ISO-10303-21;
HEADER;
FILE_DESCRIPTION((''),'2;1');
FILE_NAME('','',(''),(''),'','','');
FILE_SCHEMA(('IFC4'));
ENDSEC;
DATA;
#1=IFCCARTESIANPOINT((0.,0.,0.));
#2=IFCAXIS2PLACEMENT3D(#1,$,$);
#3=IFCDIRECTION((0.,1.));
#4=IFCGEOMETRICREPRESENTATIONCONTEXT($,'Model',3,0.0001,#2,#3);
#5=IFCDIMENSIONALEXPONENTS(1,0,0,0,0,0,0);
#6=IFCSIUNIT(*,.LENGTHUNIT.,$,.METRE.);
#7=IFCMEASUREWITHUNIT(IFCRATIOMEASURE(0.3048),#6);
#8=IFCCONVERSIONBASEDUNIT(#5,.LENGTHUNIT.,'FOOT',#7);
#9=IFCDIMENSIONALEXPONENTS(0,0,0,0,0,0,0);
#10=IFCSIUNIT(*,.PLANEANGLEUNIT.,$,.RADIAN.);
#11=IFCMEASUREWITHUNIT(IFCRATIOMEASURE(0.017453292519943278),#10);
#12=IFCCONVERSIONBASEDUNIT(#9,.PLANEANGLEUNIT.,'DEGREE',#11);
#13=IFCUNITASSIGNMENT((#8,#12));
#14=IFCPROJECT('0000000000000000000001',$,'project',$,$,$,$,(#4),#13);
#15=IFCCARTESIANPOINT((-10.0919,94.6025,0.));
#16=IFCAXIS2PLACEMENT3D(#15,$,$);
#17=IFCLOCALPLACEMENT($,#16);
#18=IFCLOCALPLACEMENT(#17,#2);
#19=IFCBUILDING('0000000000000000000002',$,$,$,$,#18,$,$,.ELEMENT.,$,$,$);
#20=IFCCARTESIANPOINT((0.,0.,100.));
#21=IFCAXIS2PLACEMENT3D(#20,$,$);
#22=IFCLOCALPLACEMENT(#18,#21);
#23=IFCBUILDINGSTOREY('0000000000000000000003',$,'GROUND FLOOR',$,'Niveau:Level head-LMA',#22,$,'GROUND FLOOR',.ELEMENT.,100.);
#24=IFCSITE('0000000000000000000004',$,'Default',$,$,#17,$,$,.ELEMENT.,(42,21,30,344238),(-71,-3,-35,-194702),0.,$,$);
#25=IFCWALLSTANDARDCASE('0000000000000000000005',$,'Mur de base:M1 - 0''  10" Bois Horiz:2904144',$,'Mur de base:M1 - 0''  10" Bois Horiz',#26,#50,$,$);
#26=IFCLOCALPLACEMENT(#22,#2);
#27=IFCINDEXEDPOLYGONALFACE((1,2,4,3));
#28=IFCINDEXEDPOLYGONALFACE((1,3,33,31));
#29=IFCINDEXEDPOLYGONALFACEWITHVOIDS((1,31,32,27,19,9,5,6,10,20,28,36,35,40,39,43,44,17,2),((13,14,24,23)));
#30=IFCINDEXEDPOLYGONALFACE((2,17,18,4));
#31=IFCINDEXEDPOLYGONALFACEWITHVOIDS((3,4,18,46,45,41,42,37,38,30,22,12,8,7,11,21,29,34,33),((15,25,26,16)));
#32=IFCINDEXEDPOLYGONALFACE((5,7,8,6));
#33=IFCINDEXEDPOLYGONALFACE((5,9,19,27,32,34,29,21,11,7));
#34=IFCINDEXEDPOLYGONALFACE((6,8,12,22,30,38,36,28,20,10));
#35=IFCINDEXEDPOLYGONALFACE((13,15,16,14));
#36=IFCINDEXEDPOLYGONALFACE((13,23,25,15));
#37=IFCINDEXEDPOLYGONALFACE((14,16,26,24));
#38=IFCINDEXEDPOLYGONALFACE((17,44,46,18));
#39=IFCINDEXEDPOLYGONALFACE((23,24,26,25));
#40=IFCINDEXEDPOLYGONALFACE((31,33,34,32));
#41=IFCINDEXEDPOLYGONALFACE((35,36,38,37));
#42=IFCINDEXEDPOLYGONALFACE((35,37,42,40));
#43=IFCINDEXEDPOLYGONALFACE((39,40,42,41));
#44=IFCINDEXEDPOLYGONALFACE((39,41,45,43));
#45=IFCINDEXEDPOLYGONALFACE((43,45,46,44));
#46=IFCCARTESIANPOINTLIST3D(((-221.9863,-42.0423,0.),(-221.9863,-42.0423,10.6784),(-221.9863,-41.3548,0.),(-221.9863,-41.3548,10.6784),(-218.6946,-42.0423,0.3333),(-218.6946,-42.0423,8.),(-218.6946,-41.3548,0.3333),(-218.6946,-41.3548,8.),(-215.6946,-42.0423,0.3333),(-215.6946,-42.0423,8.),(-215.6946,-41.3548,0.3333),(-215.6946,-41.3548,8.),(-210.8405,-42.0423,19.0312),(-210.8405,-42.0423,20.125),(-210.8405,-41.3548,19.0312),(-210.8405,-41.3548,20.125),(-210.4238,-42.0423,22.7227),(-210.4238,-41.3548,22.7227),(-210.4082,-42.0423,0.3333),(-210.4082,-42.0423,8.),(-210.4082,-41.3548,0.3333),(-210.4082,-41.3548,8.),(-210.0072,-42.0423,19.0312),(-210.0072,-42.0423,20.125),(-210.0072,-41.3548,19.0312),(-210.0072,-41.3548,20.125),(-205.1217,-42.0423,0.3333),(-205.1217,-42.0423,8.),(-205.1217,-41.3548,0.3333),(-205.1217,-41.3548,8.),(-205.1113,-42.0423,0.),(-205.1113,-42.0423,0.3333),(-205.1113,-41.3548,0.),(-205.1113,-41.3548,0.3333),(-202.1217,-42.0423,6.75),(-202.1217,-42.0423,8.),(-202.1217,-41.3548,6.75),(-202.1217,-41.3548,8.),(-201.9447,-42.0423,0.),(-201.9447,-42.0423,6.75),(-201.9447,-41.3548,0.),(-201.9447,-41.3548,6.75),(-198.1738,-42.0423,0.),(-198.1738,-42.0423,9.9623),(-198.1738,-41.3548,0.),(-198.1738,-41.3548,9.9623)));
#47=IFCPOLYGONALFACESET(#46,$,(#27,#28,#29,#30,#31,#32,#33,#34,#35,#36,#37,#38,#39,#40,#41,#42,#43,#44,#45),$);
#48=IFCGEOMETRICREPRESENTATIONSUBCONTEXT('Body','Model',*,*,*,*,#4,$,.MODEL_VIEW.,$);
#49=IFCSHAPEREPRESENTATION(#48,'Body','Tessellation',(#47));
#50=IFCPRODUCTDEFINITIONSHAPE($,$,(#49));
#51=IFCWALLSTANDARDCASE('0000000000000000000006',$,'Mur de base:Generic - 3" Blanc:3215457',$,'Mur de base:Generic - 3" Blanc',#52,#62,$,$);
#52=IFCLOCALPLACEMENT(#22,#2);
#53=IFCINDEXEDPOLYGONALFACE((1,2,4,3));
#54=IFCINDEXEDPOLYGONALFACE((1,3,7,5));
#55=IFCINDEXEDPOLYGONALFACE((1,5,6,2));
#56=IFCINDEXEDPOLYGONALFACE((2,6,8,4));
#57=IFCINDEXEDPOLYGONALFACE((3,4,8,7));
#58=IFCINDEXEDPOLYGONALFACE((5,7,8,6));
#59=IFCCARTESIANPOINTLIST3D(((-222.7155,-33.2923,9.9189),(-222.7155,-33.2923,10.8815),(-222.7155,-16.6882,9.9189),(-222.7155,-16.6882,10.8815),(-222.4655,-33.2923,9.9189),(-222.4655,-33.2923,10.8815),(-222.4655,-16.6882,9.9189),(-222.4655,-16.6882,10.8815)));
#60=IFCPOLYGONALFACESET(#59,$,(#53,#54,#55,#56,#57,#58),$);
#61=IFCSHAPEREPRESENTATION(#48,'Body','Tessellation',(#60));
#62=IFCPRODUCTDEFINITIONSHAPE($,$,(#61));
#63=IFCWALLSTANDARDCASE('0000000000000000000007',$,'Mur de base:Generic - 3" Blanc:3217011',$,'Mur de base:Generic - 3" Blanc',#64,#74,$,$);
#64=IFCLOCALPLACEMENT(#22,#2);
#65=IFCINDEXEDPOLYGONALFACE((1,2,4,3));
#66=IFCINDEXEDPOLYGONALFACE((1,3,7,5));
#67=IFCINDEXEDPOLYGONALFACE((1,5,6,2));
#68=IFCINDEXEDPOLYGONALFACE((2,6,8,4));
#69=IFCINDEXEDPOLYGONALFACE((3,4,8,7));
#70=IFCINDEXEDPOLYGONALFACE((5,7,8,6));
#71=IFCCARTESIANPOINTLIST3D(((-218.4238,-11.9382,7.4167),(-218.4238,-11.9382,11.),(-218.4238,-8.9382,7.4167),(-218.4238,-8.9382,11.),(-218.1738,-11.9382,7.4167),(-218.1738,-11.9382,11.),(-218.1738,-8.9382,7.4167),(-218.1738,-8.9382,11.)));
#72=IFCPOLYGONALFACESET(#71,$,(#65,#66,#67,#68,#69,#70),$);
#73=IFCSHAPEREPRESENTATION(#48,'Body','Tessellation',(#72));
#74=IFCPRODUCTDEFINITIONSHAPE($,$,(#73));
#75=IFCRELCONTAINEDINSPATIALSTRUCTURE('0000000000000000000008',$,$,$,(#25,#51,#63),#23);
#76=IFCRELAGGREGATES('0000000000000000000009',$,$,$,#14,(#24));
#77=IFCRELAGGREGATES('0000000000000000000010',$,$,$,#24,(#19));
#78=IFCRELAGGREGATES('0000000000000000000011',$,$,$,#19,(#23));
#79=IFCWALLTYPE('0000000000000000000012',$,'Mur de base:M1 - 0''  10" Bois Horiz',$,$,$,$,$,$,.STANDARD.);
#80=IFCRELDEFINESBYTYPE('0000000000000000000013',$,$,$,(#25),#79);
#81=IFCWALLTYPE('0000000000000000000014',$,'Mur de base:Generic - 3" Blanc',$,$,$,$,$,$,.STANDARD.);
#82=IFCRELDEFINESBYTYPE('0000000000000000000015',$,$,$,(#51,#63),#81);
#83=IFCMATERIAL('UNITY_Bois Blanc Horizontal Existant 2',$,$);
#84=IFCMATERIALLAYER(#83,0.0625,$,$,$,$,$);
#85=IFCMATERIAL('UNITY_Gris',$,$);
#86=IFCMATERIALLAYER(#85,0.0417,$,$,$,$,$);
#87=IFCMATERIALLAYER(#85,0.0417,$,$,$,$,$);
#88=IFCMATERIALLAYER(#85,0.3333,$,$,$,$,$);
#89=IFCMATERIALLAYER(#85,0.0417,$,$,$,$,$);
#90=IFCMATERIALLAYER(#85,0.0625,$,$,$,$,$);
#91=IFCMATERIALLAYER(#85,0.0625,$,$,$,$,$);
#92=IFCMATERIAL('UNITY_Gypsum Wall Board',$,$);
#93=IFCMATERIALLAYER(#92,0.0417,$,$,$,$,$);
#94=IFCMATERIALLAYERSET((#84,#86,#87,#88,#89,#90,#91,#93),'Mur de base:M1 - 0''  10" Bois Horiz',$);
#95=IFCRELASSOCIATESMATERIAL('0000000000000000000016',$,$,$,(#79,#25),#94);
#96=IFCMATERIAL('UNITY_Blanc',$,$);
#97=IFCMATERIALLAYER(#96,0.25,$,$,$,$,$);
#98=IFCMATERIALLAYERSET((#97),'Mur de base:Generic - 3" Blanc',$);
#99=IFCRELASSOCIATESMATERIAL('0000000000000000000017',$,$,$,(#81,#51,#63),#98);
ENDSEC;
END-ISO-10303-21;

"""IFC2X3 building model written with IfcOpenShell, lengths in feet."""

from ifc_helpers import new_model, entity, si_unit, converted_unit, direction, frame, frame_2d, origin, place, context, subcontext, project, spatial, polyline, rectangle, extrude, clip, bounded_halfspace, material, layer, layer_set, layer_usage, type_object, element, save


model = new_model("IFC2X3")

# Units and contexts
model_context = context("Model", 3, precision=0.0001, world=origin(), true_north=direction((0.0, 1.0)))
body_context = subcontext(model_context, "Body", "Model", "MODEL_VIEW")
ifc_project = project(units=[converted_unit("LENGTHUNIT", "FOOT", entity("IfcRatioMeasure", 0.3048), si_unit("LENGTHUNIT", "METRE"), dimensions=[1, 0, 0, 0, 0, 0, 0]), converted_unit("PLANEANGLEUNIT", "DEGREE", entity("IfcRatioMeasure", 0.017453292519943278), si_unit("PLANEANGLEUNIT", "RADIAN"), dimensions=[0, 0, 0, 0, 0, 0, 0])], contexts=[model_context])

# Site, building, storey
site_placement = place(None, frame((-10.0919, 94.6025, 0.0)))
site = spatial("IfcSite", under=ifc_project, at=site_placement, Name="Default", CompositionType="ELEMENT", RefLatitude=(42, 21, 30, 344238), RefLongitude=(-71, -3, -35, -194702), RefElevation=0.0)
building_placement = place(site_placement, origin())
building = spatial("IfcBuilding", under=site, at=building_placement, CompositionType="ELEMENT")
storey_placement = place(building_placement, frame((0.0, 0.0, 100.0)))
storey = spatial("IfcBuildingStorey", under=building, at=storey_placement, Name="GROUND FLOOR", ObjectType="Niveau:Level head-LMA", LongName="GROUND FLOOR", CompositionType="ELEMENT", Elevation=100.0)

# Wall, openings
ifc_material_1 = material(Name="UNITY_Bois Blanc Horizontal Existant 2")
ifc_layer_1 = layer(ifc_material_1, 0.0625)
ifc_material_2 = material(Name="UNITY_Gris")
ifc_layer_2 = layer(ifc_material_2, 0.0417)
ifc_layer_3 = layer(ifc_material_2, 0.0417)
ifc_layer_4 = layer(ifc_material_2, 0.3333)
ifc_layer_5 = layer(ifc_material_2, 0.0417)
ifc_layer_6 = layer(ifc_material_2, 0.0625)
ifc_layer_7 = layer(ifc_material_2, 0.0625)
ifc_material_3 = material(Name="UNITY_Gypsum Wall Board")
ifc_layer_8 = layer(ifc_material_3, 0.0417)
ifc_layer_set_1 = layer_set([ifc_layer_1, ifc_layer_2, ifc_layer_3, ifc_layer_4, ifc_layer_5, ifc_layer_6, ifc_layer_7, ifc_layer_8], Name="Mur de base:M1 - 0'  10\" Bois Horiz")
ifc_layer_usage_1 = layer_usage(ifc_layer_set_1, "AXIS2", "POSITIVE", -0.3438)
wall_type_1 = type_object("IfcWallType", Name="Mur de base:M1 - 0'  10\" Bois Horiz", PredefinedType="STANDARD", material=ifc_layer_set_1)
wall_1_placement = place(storey_placement, frame((-221.9863, -41.6986, 0.0)))
wall_1 = element("IfcWallStandardCase", 1, at=wall_1_placement, inside=storey, type_object=wall_type_1, material=ifc_layer_usage_1, Name="Mur de base:M1 - 0'  10\" Bois Horiz:2904144", ObjectType="Mur de base:M1 - 0'  10\" Bois Horiz", context=body_context, shape_type="Clipping", body=[
    clip(clip(extrude(rectangle(XDim=23.8125, YDim=0.6875, at=frame_2d((11.9062, 0.0), x_axis=(-1.0, 0.0))), origin(), (0.0, 0.0, 1.0), 22.7227), bounded_halfspace(frame((0.0, -0.3438, 10.6784), z_axis=(-0.721387, 0.0, 0.692532), x_axis=(0.0, -1.0, 0.0)), False, frame((0.0, -0.3438, 10.6784)), polyline([(0.0, 0.0), (11.5625, 0.0), (11.5625, 0.6875), (0.0, 0.6875), (0.0, 0.0)]))), bounded_halfspace(frame((23.8125, -0.3438, 9.9623), z_axis=(0.721387, 0.0, 0.692532), x_axis=(0.0, 1.0, 0.0)), False, frame((23.8125, -0.3438, 9.9623)), polyline([(0.0, 0.0), (0.0, 0.6875), (-0.6875, 0.6875), (-12.25, 0.6875), (-12.25, 0.0), (0.0, 0.0)]))),
])
opening_1_placement = place(wall_1_placement, frame((221.9863, 41.6986, 0.0)))
element("IfcOpeningElement", 2, at=opening_1_placement, cuts=wall_1, ObjectType="Opening", context=body_context, shape_type="SweptSolid", body=[
    extrude(rectangle(XDim=6.75, YDim=3.1667, at=frame_2d((0.0, 0.0), x_axis=(0.0, 1.0))), frame((-203.528, -47.0423, 3.375), z_axis=(0.0, 1.0, 0.0), x_axis=(-1.0, 0.0, 0.0)), (0.0, 0.0, 1.0), 10.0),
])
opening_2_placement = place(wall_1_placement, frame((221.9863, 41.6986, 0.0)))
element("IfcOpeningElement", 3, at=opening_2_placement, cuts=wall_1, ObjectType="Opening", context=body_context, shape_type="SweptSolid", body=[
    extrude(rectangle(XDim=7.6667, YDim=5.2865, at=frame_2d((0.0, 0.0), x_axis=(0.0, 1.0))), frame((-207.765, -46.3548, 4.1667), z_axis=(0.0, 1.0, 0.0), x_axis=(-1.0, 0.0, 0.0)), (0.0, 0.0, 1.0), 10.0),
])
opening_3_placement = place(wall_1_placement, frame((221.9863, 41.6986, 0.0)))
element("IfcOpeningElement", 4, at=opening_3_placement, cuts=wall_1, ObjectType="Opening", context=body_context, shape_type="SweptSolid", body=[
    extrude(rectangle(XDim=7.6667, YDim=3.0, at=frame_2d((0.0, 0.0), x_axis=(0.0, 1.0))), frame((-203.6217, -46.3548, 4.1667), z_axis=(0.0, 1.0, 0.0), x_axis=(-1.0, 0.0, 0.0)), (0.0, 0.0, 1.0), 10.0),
])
opening_4_placement = place(wall_1_placement, frame((221.9863, 41.6986, 0.0)))
element("IfcOpeningElement", 5, at=opening_4_placement, cuts=wall_1, ObjectType="Opening", context=body_context, shape_type="SweptSolid", body=[
    extrude(rectangle(XDim=3.2708, YDim=5.125, at=frame_2d((0.0, 0.0), x_axis=(0.0, 1.0))), frame((-210.403, -46.3548, 5.6875), z_axis=(0.0, 1.0, 0.0), x_axis=(-1.0, 0.0, 0.0)), (0.0, 0.0, 1.0), 10.0),
])
opening_5_placement = place(wall_1_placement, frame((221.9863, 41.6986, 0.0)))
element("IfcOpeningElement", 6, at=opening_5_placement, cuts=wall_1, ObjectType="Opening", context=body_context, shape_type="SweptSolid", body=[
    extrude(rectangle(XDim=7.6667, YDim=5.2865, at=frame_2d((0.0, 0.0), x_axis=(0.0, 1.0))), frame((-213.0514, -46.3548, 4.1667), z_axis=(0.0, 1.0, 0.0), x_axis=(-1.0, 0.0, 0.0)), (0.0, 0.0, 1.0), 10.0),
])
opening_6_placement = place(wall_1_placement, frame((221.9863, 41.6986, 0.0)))
element("IfcOpeningElement", 7, at=opening_6_placement, cuts=wall_1, ObjectType="Opening", context=body_context, shape_type="SweptSolid", body=[
    extrude(rectangle(XDim=7.6667, YDim=3.0, at=frame_2d((0.0, 0.0), x_axis=(0.0, 1.0))), frame((-217.1946, -46.3548, 4.1667), z_axis=(0.0, 1.0, 0.0), x_axis=(-1.0, 0.0, 0.0)), (0.0, 0.0, 1.0), 10.0),
])
opening_7_placement = place(wall_1_placement, frame((221.9863, 41.6986, 10.3333)))
element("IfcOpeningElement", 8, at=opening_7_placement, cuts=wall_1, ObjectType="Opening", context=body_context, shape_type="SweptSolid", body=[
    extrude(rectangle(XDim=1.0938, YDim=0.8333, at=frame_2d((0.0, 0.0), x_axis=(0.0, 1.0))), frame((-210.4238, -46.3548, 9.2448), z_axis=(0.0, 1.0, 0.0), x_axis=(-1.0, 0.0, 0.0)), (0.0, 0.0, 1.0), 10.0),
])
ifc_material_4 = material(Name="UNITY_Blanc")
ifc_layer_9 = layer(ifc_material_4, 0.25)
ifc_layer_set_2 = layer_set([ifc_layer_9], Name="Mur de base:Generic - 3\" Blanc")
wall_type_2 = type_object("IfcWallType", Name="Mur de base:Generic - 3\" Blanc", PredefinedType="STANDARD", material=ifc_layer_set_2)

# Walls
ifc_layer_usage_2 = layer_usage(ifc_layer_set_2, "AXIS2", "POSITIVE", -0.125)
wall_2_placement = place(storey_placement, frame((-222.5905, -16.6882, 9.9189), z_axis=(0.0, 0.0, 1.0), x_axis=(0.0, -1.0, 0.0)))
element("IfcWallStandardCase", 9, at=wall_2_placement, inside=storey, type_object=wall_type_2, material=ifc_layer_usage_2, Name="Mur de base:Generic - 3\" Blanc:3215457", ObjectType="Mur de base:Generic - 3\" Blanc", context=body_context, shape_type="SweptSolid", body=[
    extrude(rectangle(XDim=16.6042, YDim=0.25, at=frame_2d((8.3021, 0.0), x_axis=(-1.0, 0.0))), origin(), (0.0, 0.0, 1.0), 0.9627),
])
ifc_layer_usage_3 = layer_usage(ifc_layer_set_2, "AXIS2", "POSITIVE", -0.125)
wall_3_placement = place(storey_placement, frame((-218.2988, -11.9382, 7.4167), z_axis=(0.0, 0.0, 1.0), x_axis=(0.0, 1.0, 0.0)))
element("IfcWallStandardCase", 10, at=wall_3_placement, inside=storey, type_object=wall_type_2, material=ifc_layer_usage_3, Name="Mur de base:Generic - 3\" Blanc:3217011", ObjectType="Mur de base:Generic - 3\" Blanc", context=body_context, shape_type="SweptSolid", body=[
    extrude(rectangle(XDim=3.0, YDim=0.25, at=frame_2d((1.5, 0.0), x_axis=(-1.0, 0.0))), origin(), (0.0, 0.0, 1.0), 3.5833),
])

save(model, "model.ifc")
